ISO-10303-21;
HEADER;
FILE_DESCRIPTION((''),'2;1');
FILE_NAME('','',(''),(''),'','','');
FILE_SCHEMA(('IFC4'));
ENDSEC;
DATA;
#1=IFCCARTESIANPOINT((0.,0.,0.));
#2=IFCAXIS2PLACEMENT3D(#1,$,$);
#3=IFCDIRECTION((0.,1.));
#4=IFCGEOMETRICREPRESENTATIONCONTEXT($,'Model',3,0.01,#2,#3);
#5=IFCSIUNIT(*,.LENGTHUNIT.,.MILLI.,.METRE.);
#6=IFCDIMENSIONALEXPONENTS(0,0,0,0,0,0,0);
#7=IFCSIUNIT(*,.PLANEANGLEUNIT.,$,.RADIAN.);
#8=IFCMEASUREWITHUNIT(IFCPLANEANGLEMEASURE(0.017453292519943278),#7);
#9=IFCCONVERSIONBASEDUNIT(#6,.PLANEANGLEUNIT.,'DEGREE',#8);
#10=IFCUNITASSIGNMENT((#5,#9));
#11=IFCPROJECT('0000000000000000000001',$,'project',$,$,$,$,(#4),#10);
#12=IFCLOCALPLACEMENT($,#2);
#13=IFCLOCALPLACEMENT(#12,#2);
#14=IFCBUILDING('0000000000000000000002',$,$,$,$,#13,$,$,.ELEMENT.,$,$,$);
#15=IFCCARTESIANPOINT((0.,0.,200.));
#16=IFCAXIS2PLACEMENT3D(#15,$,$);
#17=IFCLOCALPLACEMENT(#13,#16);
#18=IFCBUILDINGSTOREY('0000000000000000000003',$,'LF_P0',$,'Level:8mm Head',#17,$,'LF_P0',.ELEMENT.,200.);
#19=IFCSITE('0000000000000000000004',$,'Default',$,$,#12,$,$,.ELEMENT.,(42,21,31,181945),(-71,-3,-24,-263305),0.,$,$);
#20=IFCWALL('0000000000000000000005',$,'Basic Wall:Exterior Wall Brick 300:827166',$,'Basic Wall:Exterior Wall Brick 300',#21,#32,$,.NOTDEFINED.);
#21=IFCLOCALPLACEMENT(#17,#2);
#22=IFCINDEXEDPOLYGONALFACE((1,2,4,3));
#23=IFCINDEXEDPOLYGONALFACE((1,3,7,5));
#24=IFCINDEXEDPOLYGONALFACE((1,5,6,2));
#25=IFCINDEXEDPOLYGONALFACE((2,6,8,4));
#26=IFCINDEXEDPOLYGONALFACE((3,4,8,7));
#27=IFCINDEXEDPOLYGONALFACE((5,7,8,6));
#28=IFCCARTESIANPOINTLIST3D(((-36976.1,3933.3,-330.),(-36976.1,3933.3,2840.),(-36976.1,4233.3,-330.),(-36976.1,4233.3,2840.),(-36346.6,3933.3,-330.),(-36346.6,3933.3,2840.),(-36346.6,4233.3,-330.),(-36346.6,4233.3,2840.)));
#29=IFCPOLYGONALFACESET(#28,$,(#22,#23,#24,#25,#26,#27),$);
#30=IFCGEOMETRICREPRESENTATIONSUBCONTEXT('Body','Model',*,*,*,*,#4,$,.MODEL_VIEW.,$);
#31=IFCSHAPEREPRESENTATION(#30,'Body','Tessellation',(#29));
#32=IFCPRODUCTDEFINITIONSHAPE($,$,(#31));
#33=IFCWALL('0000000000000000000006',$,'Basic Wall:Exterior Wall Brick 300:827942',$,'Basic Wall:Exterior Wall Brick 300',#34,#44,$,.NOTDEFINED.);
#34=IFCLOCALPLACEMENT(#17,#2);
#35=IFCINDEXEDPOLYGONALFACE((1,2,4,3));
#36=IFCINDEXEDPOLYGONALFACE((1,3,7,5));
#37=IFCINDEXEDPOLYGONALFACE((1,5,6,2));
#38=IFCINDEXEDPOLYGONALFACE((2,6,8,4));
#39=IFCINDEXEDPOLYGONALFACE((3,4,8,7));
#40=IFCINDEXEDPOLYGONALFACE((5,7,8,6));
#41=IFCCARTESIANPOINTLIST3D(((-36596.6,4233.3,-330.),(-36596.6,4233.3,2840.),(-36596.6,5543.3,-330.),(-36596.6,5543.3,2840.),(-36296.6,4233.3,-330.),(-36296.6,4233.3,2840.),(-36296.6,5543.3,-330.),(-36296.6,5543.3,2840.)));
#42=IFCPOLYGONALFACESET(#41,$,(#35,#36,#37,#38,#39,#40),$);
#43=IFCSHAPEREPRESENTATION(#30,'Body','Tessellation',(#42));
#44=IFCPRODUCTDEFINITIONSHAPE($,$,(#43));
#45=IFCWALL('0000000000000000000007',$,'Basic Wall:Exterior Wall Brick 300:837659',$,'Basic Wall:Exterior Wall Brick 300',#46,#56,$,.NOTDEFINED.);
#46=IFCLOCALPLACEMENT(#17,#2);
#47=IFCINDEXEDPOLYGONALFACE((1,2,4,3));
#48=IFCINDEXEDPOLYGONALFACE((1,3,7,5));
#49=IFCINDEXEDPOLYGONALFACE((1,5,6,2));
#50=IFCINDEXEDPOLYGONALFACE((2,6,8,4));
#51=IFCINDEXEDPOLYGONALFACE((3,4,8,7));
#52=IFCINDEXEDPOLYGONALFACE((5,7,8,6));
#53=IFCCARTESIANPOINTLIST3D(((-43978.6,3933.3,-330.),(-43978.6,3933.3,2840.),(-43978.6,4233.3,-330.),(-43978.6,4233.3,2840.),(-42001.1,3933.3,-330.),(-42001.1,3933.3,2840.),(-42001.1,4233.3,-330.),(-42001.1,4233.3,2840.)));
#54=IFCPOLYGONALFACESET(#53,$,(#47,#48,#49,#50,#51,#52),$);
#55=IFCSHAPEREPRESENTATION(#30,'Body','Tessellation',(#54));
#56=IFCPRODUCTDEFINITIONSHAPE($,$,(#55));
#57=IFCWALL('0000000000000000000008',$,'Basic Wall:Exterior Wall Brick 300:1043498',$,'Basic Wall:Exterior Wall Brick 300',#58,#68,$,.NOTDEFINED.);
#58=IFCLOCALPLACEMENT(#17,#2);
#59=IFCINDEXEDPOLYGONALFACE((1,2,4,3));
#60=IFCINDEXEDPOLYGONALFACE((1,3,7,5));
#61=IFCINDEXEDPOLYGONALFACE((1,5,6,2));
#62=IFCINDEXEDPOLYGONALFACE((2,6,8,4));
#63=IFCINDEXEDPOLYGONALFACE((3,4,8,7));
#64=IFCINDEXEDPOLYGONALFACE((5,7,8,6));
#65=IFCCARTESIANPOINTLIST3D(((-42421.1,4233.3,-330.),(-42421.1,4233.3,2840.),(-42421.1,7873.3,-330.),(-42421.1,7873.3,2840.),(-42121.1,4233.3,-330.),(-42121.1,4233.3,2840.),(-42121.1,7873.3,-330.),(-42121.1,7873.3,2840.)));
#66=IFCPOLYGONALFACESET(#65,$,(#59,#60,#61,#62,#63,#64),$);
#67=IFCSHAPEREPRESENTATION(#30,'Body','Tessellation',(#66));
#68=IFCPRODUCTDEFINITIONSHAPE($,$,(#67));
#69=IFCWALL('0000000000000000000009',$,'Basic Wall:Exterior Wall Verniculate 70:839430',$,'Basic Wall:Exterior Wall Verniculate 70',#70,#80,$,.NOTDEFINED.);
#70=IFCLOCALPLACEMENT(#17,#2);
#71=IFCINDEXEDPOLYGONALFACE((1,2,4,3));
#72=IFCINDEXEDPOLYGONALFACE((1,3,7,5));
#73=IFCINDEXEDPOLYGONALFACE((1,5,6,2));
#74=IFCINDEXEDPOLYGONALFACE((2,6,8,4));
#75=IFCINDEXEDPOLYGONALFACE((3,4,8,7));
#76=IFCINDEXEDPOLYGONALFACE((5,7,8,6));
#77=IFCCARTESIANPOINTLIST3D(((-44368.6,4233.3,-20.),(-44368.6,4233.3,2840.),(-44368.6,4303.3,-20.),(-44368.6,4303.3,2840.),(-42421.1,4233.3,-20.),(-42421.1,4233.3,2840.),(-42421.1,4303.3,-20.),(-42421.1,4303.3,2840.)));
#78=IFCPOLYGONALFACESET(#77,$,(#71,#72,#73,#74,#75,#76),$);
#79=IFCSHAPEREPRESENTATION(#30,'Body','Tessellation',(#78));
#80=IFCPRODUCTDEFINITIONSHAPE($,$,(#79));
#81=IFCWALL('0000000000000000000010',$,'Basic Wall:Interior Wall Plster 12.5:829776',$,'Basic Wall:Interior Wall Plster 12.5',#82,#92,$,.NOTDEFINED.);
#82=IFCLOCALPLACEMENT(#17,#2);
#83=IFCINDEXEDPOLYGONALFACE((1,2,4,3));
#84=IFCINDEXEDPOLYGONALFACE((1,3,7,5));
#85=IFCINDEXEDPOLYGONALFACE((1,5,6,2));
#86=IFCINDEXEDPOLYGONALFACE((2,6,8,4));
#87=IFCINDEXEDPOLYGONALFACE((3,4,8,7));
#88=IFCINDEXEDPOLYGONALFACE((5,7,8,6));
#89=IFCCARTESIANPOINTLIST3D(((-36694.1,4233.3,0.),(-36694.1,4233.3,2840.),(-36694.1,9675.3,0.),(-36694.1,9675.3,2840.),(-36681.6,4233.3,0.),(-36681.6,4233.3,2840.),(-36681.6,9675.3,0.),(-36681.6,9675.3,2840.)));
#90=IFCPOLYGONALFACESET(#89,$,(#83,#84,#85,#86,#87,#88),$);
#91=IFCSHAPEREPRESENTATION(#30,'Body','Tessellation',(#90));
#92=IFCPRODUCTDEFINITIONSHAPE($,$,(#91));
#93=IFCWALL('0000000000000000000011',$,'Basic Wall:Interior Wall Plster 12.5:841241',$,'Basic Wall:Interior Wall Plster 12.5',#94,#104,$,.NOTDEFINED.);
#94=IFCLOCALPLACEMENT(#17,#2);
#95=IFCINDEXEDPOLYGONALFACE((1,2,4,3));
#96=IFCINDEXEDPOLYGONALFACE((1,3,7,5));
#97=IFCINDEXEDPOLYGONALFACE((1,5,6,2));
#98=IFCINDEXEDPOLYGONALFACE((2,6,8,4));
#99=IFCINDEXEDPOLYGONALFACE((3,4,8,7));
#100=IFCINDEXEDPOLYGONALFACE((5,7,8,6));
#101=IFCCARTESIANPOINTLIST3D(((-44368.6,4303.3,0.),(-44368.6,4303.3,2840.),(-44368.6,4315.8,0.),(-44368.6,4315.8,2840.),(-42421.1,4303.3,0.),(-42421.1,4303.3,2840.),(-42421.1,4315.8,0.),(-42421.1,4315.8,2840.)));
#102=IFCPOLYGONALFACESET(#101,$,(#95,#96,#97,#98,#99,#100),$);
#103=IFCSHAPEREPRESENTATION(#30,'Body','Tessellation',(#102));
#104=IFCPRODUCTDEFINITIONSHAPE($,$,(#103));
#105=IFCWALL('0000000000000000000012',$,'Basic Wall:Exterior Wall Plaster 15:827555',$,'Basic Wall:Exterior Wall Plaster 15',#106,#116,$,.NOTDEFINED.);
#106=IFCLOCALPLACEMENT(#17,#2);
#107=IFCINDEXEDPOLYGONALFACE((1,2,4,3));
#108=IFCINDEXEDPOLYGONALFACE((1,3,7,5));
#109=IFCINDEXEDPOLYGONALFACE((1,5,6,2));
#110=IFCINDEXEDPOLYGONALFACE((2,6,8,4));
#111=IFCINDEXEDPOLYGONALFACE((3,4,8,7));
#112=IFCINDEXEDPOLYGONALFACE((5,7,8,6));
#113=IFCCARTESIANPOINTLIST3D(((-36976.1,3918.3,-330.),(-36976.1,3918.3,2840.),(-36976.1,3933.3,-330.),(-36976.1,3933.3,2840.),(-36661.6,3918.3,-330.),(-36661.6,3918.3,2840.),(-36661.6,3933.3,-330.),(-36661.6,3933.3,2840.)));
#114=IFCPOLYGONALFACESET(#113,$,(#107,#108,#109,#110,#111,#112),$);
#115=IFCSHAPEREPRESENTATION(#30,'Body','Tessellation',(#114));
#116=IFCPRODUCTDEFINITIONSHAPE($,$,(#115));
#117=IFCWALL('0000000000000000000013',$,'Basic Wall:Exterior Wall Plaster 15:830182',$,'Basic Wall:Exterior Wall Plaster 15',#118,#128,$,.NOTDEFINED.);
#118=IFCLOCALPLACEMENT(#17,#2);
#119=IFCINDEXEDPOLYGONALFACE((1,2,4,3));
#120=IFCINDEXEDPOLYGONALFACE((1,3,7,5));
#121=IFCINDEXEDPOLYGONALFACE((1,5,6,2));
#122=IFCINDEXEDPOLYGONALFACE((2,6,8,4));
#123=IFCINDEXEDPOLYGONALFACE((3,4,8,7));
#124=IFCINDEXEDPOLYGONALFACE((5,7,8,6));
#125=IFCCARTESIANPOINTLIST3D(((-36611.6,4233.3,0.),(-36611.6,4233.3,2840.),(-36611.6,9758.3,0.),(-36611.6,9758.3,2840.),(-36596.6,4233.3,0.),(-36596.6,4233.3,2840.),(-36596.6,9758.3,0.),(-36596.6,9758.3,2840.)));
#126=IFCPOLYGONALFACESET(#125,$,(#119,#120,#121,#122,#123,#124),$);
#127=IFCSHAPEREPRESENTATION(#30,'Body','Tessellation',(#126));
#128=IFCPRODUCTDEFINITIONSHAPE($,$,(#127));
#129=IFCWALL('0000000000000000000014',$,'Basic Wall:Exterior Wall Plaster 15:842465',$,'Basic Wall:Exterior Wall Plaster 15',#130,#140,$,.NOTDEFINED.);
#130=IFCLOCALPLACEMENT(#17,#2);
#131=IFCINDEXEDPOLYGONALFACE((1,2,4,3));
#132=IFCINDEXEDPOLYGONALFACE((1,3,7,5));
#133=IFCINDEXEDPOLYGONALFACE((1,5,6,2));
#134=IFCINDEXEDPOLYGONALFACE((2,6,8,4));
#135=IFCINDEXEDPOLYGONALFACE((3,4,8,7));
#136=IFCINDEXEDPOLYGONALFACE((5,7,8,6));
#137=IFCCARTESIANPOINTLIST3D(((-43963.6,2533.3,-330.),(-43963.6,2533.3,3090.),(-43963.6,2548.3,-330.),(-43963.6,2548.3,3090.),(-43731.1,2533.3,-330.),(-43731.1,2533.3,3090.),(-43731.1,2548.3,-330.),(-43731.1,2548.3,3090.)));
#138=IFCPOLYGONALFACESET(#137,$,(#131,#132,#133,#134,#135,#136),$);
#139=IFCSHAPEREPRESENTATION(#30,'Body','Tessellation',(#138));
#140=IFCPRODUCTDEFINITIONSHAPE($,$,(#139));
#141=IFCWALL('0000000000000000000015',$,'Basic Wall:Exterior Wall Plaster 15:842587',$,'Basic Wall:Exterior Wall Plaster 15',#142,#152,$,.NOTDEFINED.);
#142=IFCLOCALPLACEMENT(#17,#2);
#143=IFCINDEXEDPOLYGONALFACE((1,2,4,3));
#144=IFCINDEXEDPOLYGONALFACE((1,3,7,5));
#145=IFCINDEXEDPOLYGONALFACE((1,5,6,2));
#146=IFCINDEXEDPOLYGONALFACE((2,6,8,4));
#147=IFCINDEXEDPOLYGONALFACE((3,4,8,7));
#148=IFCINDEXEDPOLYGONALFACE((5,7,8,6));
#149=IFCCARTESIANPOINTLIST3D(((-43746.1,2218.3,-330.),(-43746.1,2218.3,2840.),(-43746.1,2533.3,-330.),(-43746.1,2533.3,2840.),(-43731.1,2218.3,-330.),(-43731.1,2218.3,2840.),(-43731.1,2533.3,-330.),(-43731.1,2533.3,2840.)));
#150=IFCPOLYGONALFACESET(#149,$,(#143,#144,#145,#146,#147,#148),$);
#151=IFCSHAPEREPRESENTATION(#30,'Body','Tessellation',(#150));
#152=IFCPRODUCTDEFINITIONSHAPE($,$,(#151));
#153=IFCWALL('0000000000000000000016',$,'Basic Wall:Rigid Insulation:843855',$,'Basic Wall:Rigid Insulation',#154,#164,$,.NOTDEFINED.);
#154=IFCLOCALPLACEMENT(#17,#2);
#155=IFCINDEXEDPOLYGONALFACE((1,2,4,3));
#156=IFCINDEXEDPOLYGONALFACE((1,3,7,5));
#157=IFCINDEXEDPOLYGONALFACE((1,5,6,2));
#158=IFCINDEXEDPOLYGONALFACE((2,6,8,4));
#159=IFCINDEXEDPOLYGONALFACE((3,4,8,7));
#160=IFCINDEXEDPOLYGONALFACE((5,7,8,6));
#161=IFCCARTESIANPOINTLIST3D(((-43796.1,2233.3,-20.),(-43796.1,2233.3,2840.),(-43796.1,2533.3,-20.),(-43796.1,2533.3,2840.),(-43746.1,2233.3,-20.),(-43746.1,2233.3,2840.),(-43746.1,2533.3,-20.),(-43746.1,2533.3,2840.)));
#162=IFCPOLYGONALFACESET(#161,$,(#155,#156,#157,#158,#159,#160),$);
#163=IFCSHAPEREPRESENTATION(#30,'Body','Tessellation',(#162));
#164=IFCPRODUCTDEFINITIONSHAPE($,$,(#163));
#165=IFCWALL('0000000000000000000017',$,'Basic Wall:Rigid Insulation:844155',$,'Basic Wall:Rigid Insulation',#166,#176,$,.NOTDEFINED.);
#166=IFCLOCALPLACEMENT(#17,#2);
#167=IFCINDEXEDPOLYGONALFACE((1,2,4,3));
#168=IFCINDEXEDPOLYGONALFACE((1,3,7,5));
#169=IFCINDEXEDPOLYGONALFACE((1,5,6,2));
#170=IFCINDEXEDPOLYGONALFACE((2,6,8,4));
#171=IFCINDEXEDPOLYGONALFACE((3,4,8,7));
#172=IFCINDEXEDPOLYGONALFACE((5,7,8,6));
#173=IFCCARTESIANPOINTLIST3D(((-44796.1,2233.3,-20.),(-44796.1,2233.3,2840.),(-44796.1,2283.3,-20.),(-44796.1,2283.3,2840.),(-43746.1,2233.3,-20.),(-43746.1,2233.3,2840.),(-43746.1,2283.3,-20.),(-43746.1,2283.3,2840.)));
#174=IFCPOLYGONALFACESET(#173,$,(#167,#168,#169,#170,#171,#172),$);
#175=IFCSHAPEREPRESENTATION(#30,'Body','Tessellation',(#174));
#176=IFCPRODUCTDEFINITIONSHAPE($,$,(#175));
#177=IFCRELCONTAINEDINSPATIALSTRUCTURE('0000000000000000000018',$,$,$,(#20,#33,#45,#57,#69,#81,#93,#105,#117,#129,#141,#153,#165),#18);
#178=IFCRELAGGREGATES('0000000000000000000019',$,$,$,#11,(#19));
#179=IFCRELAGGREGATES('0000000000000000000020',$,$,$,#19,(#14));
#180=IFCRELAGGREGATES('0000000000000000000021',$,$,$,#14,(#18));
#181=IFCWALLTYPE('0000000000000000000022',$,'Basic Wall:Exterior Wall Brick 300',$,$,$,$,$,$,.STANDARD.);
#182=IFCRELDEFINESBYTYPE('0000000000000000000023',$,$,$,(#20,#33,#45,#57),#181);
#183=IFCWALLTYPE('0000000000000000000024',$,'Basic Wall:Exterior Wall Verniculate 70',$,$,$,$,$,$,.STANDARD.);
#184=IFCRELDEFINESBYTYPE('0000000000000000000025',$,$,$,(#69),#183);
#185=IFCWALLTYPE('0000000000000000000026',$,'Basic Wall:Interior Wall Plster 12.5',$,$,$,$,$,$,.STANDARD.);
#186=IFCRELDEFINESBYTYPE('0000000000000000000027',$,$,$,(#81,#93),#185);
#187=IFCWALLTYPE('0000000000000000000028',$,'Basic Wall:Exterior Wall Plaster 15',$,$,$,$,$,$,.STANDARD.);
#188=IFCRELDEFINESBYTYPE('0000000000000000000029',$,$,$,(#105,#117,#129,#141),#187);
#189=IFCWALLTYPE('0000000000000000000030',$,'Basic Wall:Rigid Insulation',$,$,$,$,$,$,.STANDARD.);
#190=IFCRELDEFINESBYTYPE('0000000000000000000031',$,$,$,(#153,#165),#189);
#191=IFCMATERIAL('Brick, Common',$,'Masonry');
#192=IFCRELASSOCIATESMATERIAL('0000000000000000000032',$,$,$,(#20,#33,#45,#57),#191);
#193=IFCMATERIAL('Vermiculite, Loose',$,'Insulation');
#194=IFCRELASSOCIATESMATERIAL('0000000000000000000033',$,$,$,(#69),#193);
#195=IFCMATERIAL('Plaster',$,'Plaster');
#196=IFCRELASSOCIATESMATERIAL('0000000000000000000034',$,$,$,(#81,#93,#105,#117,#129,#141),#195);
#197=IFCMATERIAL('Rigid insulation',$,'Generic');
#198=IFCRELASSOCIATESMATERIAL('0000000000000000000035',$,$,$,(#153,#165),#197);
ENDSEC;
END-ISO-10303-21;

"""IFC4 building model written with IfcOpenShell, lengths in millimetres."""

from ifc_helpers import new_model, entity, si_unit, converted_unit, direction, frame, origin, place, context, subcontext, project, spatial, indexed_curve, outline, extrude, material, type_object, element, save


model = new_model("IFC4")

# Units and contexts
model_context = context("Model", 3, precision=0.01, world=origin(), true_north=direction((0.0, 1.0)))
body_context = subcontext(model_context, "Body", "Model", "MODEL_VIEW")
ifc_project = project(units=[si_unit("LENGTHUNIT", "METRE", prefix="MILLI"), converted_unit("PLANEANGLEUNIT", "DEGREE", entity("IfcPlaneAngleMeasure", 0.017453292519943278), si_unit("PLANEANGLEUNIT", "RADIAN"), dimensions=[0, 0, 0, 0, 0, 0, 0])], contexts=[model_context])

# Site, building, storey
site_placement = place(None, origin())
site = spatial("IfcSite", under=ifc_project, at=site_placement, Name="Default", CompositionType="ELEMENT", RefLatitude=(42, 21, 31, 181945), RefLongitude=(-71, -3, -24, -263305), RefElevation=0.0)
building_placement = place(site_placement, origin())
building = spatial("IfcBuilding", under=site, at=building_placement, CompositionType="ELEMENT")
storey_placement = place(building_placement, frame((0.0, 0.0, 200.0)))
storey = spatial("IfcBuildingStorey", under=building, at=storey_placement, Name="LF_P0", ObjectType="Level:8mm Head", LongName="LF_P0", CompositionType="ELEMENT", Elevation=200.0)

# Walls
ifc_material_1 = material(Name="Brick, Common", Category="Masonry")
wall_type_1 = type_object("IfcWallType", Name="Basic Wall:Exterior Wall Brick 300", PredefinedType="STANDARD")
wall_1_placement = place(storey_placement, frame((-36346.6, 4083.3, -330.0), z_axis=(0.0, 0.0, 1.0), x_axis=(-1.0, 0.0, 0.0)))
element("IfcWall", 1, at=wall_1_placement, inside=storey, type_object=wall_type_1, material=ifc_material_1, Name="Basic Wall:Exterior Wall Brick 300:827166", ObjectType="Basic Wall:Exterior Wall Brick 300", PredefinedType="NOTDEFINED", context=body_context, shape_type="SweptSolid", body=[
    extrude(outline(indexed_curve([(629.5, 150.0), (0.0, 150.0), (0.0, -150.0), (629.5, -150.0), (629.5, 150.0)], self_intersect=False)), origin(), (0.0, 0.0, 1.0), 3170.0),
])
wall_2_placement = place(storey_placement, frame((-36446.6, 4233.3, -330.0), z_axis=(0.0, 0.0, 1.0), x_axis=(0.0, 1.0, 0.0)))
element("IfcWall", 2, at=wall_2_placement, inside=storey, type_object=wall_type_1, material=ifc_material_1, Name="Basic Wall:Exterior Wall Brick 300:827942", ObjectType="Basic Wall:Exterior Wall Brick 300", PredefinedType="NOTDEFINED", context=body_context, shape_type="SweptSolid", body=[
    extrude(outline(indexed_curve([(1310.0, 150.0), (0.0, 150.0), (0.0, -150.0), (1310.0, -150.0), (1310.0, 150.0)], self_intersect=False)), origin(), (0.0, 0.0, 1.0), 3170.0),
])
wall_3_placement = place(storey_placement, frame((-42001.1, 4083.3, -330.0), z_axis=(0.0, 0.0, 1.0), x_axis=(-1.0, 0.0, 0.0)))
element("IfcWall", 3, at=wall_3_placement, inside=storey, type_object=wall_type_1, material=ifc_material_1, Name="Basic Wall:Exterior Wall Brick 300:837659", ObjectType="Basic Wall:Exterior Wall Brick 300", PredefinedType="NOTDEFINED", context=body_context, shape_type="SweptSolid", body=[
    extrude(outline(indexed_curve([(1977.5, 150.0), (0.0, 150.0), (0.0, -150.0), (1977.5, -150.0), (1977.5, 150.0)], self_intersect=False)), origin(), (0.0, 0.0, 1.0), 3170.0),
])
wall_4_placement = place(storey_placement, frame((-42271.1, 7873.3, -330.0), z_axis=(0.0, 0.0, 1.0), x_axis=(0.0, -1.0, 0.0)))
element("IfcWall", 4, at=wall_4_placement, inside=storey, type_object=wall_type_1, material=ifc_material_1, Name="Basic Wall:Exterior Wall Brick 300:1043498", ObjectType="Basic Wall:Exterior Wall Brick 300", PredefinedType="NOTDEFINED", context=body_context, shape_type="SweptSolid", body=[
    extrude(outline(indexed_curve([(3640.0, 150.0), (0.0, 150.0), (0.0, -150.0), (3640.0, -150.0), (3640.0, 150.0)], self_intersect=False)), origin(), (0.0, 0.0, 1.0), 3170.0),
])
ifc_material_2 = material(Name="Vermiculite, Loose", Category="Insulation")
wall_type_2 = type_object("IfcWallType", Name="Basic Wall:Exterior Wall Verniculate 70", PredefinedType="STANDARD")
wall_5_placement = place(storey_placement, frame((-42421.1, 4268.3, -20.0), z_axis=(0.0, 0.0, 1.0), x_axis=(-1.0, 0.0, 0.0)))
element("IfcWall", 5, at=wall_5_placement, inside=storey, type_object=wall_type_2, material=ifc_material_2, Name="Basic Wall:Exterior Wall Verniculate 70:839430", ObjectType="Basic Wall:Exterior Wall Verniculate 70", PredefinedType="NOTDEFINED", context=body_context, shape_type="SweptSolid", body=[
    extrude(outline(indexed_curve([(1947.5, 35.0), (0.0, 35.0), (0.0, -35.0), (1947.5, -35.0), (1947.5, 35.0)], self_intersect=False)), origin(), (0.0, 0.0, 1.0), 2860.0),
])
ifc_material_3 = material(Name="Plaster", Category="Plaster")
wall_type_3 = type_object("IfcWallType", Name="Basic Wall:Interior Wall Plster 12.5", PredefinedType="STANDARD")
wall_6_placement = place(storey_placement, frame((-36687.9, 4233.3, 0.0), z_axis=(0.0, 0.0, 1.0), x_axis=(0.0, 1.0, 0.0)))
element("IfcWall", 6, at=wall_6_placement, inside=storey, type_object=wall_type_3, material=ifc_material_3, Name="Basic Wall:Interior Wall Plster 12.5:829776", ObjectType="Basic Wall:Interior Wall Plster 12.5", PredefinedType="NOTDEFINED", context=body_context, shape_type="SweptSolid", body=[
    extrude(outline(indexed_curve([(5442.0, 6.2), (0.0, 6.2), (0.0, -6.2), (5442.0, -6.2), (5442.0, 6.2)], self_intersect=False)), origin(), (0.0, 0.0, 1.0), 2840.0),
])
wall_7_placement = place(storey_placement, frame((-42421.1, 4309.6, 0.0), z_axis=(0.0, 0.0, 1.0), x_axis=(-1.0, 0.0, 0.0)))
element("IfcWall", 7, at=wall_7_placement, inside=storey, type_object=wall_type_3, material=ifc_material_3, Name="Basic Wall:Interior Wall Plster 12.5:841241", ObjectType="Basic Wall:Interior Wall Plster 12.5", PredefinedType="NOTDEFINED", context=body_context, shape_type="SweptSolid", body=[
    extrude(outline(indexed_curve([(1947.5, 6.2), (0.0, 6.3), (0.0, -6.3), (1947.5, -6.3), (1947.5, 6.2)], self_intersect=False)), origin(), (0.0, 0.0, 1.0), 2840.0),
])
wall_type_4 = type_object("IfcWallType", Name="Basic Wall:Exterior Wall Plaster 15", PredefinedType="STANDARD")
wall_8_placement = place(storey_placement, frame((-36661.6, 3925.8, -330.0), z_axis=(0.0, 0.0, 1.0), x_axis=(-1.0, 0.0, 0.0)))
element("IfcWall", 8, at=wall_8_placement, inside=storey, type_object=wall_type_4, material=ifc_material_3, Name="Basic Wall:Exterior Wall Plaster 15:827555", ObjectType="Basic Wall:Exterior Wall Plaster 15", PredefinedType="NOTDEFINED", context=body_context, shape_type="SweptSolid", body=[
    extrude(outline(indexed_curve([(314.5, 7.5), (0.0, 7.5), (0.0, -7.5), (314.5, -7.5), (314.5, 7.5)], self_intersect=False)), origin(), (0.0, 0.0, 1.0), 3170.0),
])
wall_9_placement = place(storey_placement, frame((-36604.1, 4233.3, 0.0), z_axis=(0.0, 0.0, 1.0), x_axis=(0.0, 1.0, 0.0)))
element("IfcWall", 9, at=wall_9_placement, inside=storey, type_object=wall_type_4, material=ifc_material_3, Name="Basic Wall:Exterior Wall Plaster 15:830182", ObjectType="Basic Wall:Exterior Wall Plaster 15", PredefinedType="NOTDEFINED", context=body_context, shape_type="SweptSolid", body=[
    extrude(outline(indexed_curve([(5525.0, 7.5), (0.0, 7.5), (0.0, -7.5), (5525.0, -7.5), (5525.0, 7.5)], self_intersect=False)), origin(), (0.0, 0.0, 1.0), 2840.0),
])
wall_10_placement = place(storey_placement, frame((-43963.6, 2540.8, -330.0)))
element("IfcWall", 10, at=wall_10_placement, inside=storey, type_object=wall_type_4, material=ifc_material_3, Name="Basic Wall:Exterior Wall Plaster 15:842465", ObjectType="Basic Wall:Exterior Wall Plaster 15", PredefinedType="NOTDEFINED", context=body_context, shape_type="SweptSolid", body=[
    extrude(outline(indexed_curve([(232.5, 7.5), (0.0, 7.5), (0.0, -7.5), (232.5, -7.5), (232.5, 7.5)], self_intersect=False)), origin(), (0.0, 0.0, 1.0), 3420.0),
])
wall_11_placement = place(storey_placement, frame((-43738.6, 2533.3, -330.0), z_axis=(0.0, 0.0, 1.0), x_axis=(0.0, -1.0, 0.0)))
element("IfcWall", 11, at=wall_11_placement, inside=storey, type_object=wall_type_4, material=ifc_material_3, Name="Basic Wall:Exterior Wall Plaster 15:842587", ObjectType="Basic Wall:Exterior Wall Plaster 15", PredefinedType="NOTDEFINED", context=body_context, shape_type="SweptSolid", body=[
    extrude(outline(indexed_curve([(315.0, 7.5), (0.0, 7.5), (0.0, -7.5), (315.0, -7.5), (315.0, 7.5)], self_intersect=False)), origin(), (0.0, 0.0, 1.0), 3170.0),
])
ifc_material_4 = material(Name="Rigid insulation", Category="Generic")
wall_type_5 = type_object("IfcWallType", Name="Basic Wall:Rigid Insulation", PredefinedType="STANDARD")
wall_12_placement = place(storey_placement, frame((-43771.1, 2533.3, -20.0), z_axis=(0.0, 0.0, 1.0), x_axis=(0.0, -1.0, 0.0)))
element("IfcWall", 12, at=wall_12_placement, inside=storey, type_object=wall_type_5, material=ifc_material_4, Name="Basic Wall:Rigid Insulation:843855", ObjectType="Basic Wall:Rigid Insulation", PredefinedType="NOTDEFINED", context=body_context, shape_type="SweptSolid", body=[
    extrude(outline(indexed_curve([(300.0, 25.0), (0.0, 25.0), (0.0, -25.0), (300.0, -25.0), (300.0, 25.0)], self_intersect=False)), origin(), (0.0, 0.0, 1.0), 2860.0),
])
wall_13_placement = place(storey_placement, frame((-43746.1, 2258.3, -20.0), z_axis=(0.0, 0.0, 1.0), x_axis=(-1.0, 0.0, 0.0)))
element("IfcWall", 13, at=wall_13_placement, inside=storey, type_object=wall_type_5, material=ifc_material_4, Name="Basic Wall:Rigid Insulation:844155", ObjectType="Basic Wall:Rigid Insulation", PredefinedType="NOTDEFINED", context=body_context, shape_type="SweptSolid", body=[
    extrude(outline(indexed_curve([(1050.0, 25.0), (0.0, 25.0), (0.0, -25.0), (1050.0, -25.0), (1050.0, 25.0)], self_intersect=False)), origin(), (0.0, 0.0, 1.0), 2860.0),
])

save(model, "model.ifc")
